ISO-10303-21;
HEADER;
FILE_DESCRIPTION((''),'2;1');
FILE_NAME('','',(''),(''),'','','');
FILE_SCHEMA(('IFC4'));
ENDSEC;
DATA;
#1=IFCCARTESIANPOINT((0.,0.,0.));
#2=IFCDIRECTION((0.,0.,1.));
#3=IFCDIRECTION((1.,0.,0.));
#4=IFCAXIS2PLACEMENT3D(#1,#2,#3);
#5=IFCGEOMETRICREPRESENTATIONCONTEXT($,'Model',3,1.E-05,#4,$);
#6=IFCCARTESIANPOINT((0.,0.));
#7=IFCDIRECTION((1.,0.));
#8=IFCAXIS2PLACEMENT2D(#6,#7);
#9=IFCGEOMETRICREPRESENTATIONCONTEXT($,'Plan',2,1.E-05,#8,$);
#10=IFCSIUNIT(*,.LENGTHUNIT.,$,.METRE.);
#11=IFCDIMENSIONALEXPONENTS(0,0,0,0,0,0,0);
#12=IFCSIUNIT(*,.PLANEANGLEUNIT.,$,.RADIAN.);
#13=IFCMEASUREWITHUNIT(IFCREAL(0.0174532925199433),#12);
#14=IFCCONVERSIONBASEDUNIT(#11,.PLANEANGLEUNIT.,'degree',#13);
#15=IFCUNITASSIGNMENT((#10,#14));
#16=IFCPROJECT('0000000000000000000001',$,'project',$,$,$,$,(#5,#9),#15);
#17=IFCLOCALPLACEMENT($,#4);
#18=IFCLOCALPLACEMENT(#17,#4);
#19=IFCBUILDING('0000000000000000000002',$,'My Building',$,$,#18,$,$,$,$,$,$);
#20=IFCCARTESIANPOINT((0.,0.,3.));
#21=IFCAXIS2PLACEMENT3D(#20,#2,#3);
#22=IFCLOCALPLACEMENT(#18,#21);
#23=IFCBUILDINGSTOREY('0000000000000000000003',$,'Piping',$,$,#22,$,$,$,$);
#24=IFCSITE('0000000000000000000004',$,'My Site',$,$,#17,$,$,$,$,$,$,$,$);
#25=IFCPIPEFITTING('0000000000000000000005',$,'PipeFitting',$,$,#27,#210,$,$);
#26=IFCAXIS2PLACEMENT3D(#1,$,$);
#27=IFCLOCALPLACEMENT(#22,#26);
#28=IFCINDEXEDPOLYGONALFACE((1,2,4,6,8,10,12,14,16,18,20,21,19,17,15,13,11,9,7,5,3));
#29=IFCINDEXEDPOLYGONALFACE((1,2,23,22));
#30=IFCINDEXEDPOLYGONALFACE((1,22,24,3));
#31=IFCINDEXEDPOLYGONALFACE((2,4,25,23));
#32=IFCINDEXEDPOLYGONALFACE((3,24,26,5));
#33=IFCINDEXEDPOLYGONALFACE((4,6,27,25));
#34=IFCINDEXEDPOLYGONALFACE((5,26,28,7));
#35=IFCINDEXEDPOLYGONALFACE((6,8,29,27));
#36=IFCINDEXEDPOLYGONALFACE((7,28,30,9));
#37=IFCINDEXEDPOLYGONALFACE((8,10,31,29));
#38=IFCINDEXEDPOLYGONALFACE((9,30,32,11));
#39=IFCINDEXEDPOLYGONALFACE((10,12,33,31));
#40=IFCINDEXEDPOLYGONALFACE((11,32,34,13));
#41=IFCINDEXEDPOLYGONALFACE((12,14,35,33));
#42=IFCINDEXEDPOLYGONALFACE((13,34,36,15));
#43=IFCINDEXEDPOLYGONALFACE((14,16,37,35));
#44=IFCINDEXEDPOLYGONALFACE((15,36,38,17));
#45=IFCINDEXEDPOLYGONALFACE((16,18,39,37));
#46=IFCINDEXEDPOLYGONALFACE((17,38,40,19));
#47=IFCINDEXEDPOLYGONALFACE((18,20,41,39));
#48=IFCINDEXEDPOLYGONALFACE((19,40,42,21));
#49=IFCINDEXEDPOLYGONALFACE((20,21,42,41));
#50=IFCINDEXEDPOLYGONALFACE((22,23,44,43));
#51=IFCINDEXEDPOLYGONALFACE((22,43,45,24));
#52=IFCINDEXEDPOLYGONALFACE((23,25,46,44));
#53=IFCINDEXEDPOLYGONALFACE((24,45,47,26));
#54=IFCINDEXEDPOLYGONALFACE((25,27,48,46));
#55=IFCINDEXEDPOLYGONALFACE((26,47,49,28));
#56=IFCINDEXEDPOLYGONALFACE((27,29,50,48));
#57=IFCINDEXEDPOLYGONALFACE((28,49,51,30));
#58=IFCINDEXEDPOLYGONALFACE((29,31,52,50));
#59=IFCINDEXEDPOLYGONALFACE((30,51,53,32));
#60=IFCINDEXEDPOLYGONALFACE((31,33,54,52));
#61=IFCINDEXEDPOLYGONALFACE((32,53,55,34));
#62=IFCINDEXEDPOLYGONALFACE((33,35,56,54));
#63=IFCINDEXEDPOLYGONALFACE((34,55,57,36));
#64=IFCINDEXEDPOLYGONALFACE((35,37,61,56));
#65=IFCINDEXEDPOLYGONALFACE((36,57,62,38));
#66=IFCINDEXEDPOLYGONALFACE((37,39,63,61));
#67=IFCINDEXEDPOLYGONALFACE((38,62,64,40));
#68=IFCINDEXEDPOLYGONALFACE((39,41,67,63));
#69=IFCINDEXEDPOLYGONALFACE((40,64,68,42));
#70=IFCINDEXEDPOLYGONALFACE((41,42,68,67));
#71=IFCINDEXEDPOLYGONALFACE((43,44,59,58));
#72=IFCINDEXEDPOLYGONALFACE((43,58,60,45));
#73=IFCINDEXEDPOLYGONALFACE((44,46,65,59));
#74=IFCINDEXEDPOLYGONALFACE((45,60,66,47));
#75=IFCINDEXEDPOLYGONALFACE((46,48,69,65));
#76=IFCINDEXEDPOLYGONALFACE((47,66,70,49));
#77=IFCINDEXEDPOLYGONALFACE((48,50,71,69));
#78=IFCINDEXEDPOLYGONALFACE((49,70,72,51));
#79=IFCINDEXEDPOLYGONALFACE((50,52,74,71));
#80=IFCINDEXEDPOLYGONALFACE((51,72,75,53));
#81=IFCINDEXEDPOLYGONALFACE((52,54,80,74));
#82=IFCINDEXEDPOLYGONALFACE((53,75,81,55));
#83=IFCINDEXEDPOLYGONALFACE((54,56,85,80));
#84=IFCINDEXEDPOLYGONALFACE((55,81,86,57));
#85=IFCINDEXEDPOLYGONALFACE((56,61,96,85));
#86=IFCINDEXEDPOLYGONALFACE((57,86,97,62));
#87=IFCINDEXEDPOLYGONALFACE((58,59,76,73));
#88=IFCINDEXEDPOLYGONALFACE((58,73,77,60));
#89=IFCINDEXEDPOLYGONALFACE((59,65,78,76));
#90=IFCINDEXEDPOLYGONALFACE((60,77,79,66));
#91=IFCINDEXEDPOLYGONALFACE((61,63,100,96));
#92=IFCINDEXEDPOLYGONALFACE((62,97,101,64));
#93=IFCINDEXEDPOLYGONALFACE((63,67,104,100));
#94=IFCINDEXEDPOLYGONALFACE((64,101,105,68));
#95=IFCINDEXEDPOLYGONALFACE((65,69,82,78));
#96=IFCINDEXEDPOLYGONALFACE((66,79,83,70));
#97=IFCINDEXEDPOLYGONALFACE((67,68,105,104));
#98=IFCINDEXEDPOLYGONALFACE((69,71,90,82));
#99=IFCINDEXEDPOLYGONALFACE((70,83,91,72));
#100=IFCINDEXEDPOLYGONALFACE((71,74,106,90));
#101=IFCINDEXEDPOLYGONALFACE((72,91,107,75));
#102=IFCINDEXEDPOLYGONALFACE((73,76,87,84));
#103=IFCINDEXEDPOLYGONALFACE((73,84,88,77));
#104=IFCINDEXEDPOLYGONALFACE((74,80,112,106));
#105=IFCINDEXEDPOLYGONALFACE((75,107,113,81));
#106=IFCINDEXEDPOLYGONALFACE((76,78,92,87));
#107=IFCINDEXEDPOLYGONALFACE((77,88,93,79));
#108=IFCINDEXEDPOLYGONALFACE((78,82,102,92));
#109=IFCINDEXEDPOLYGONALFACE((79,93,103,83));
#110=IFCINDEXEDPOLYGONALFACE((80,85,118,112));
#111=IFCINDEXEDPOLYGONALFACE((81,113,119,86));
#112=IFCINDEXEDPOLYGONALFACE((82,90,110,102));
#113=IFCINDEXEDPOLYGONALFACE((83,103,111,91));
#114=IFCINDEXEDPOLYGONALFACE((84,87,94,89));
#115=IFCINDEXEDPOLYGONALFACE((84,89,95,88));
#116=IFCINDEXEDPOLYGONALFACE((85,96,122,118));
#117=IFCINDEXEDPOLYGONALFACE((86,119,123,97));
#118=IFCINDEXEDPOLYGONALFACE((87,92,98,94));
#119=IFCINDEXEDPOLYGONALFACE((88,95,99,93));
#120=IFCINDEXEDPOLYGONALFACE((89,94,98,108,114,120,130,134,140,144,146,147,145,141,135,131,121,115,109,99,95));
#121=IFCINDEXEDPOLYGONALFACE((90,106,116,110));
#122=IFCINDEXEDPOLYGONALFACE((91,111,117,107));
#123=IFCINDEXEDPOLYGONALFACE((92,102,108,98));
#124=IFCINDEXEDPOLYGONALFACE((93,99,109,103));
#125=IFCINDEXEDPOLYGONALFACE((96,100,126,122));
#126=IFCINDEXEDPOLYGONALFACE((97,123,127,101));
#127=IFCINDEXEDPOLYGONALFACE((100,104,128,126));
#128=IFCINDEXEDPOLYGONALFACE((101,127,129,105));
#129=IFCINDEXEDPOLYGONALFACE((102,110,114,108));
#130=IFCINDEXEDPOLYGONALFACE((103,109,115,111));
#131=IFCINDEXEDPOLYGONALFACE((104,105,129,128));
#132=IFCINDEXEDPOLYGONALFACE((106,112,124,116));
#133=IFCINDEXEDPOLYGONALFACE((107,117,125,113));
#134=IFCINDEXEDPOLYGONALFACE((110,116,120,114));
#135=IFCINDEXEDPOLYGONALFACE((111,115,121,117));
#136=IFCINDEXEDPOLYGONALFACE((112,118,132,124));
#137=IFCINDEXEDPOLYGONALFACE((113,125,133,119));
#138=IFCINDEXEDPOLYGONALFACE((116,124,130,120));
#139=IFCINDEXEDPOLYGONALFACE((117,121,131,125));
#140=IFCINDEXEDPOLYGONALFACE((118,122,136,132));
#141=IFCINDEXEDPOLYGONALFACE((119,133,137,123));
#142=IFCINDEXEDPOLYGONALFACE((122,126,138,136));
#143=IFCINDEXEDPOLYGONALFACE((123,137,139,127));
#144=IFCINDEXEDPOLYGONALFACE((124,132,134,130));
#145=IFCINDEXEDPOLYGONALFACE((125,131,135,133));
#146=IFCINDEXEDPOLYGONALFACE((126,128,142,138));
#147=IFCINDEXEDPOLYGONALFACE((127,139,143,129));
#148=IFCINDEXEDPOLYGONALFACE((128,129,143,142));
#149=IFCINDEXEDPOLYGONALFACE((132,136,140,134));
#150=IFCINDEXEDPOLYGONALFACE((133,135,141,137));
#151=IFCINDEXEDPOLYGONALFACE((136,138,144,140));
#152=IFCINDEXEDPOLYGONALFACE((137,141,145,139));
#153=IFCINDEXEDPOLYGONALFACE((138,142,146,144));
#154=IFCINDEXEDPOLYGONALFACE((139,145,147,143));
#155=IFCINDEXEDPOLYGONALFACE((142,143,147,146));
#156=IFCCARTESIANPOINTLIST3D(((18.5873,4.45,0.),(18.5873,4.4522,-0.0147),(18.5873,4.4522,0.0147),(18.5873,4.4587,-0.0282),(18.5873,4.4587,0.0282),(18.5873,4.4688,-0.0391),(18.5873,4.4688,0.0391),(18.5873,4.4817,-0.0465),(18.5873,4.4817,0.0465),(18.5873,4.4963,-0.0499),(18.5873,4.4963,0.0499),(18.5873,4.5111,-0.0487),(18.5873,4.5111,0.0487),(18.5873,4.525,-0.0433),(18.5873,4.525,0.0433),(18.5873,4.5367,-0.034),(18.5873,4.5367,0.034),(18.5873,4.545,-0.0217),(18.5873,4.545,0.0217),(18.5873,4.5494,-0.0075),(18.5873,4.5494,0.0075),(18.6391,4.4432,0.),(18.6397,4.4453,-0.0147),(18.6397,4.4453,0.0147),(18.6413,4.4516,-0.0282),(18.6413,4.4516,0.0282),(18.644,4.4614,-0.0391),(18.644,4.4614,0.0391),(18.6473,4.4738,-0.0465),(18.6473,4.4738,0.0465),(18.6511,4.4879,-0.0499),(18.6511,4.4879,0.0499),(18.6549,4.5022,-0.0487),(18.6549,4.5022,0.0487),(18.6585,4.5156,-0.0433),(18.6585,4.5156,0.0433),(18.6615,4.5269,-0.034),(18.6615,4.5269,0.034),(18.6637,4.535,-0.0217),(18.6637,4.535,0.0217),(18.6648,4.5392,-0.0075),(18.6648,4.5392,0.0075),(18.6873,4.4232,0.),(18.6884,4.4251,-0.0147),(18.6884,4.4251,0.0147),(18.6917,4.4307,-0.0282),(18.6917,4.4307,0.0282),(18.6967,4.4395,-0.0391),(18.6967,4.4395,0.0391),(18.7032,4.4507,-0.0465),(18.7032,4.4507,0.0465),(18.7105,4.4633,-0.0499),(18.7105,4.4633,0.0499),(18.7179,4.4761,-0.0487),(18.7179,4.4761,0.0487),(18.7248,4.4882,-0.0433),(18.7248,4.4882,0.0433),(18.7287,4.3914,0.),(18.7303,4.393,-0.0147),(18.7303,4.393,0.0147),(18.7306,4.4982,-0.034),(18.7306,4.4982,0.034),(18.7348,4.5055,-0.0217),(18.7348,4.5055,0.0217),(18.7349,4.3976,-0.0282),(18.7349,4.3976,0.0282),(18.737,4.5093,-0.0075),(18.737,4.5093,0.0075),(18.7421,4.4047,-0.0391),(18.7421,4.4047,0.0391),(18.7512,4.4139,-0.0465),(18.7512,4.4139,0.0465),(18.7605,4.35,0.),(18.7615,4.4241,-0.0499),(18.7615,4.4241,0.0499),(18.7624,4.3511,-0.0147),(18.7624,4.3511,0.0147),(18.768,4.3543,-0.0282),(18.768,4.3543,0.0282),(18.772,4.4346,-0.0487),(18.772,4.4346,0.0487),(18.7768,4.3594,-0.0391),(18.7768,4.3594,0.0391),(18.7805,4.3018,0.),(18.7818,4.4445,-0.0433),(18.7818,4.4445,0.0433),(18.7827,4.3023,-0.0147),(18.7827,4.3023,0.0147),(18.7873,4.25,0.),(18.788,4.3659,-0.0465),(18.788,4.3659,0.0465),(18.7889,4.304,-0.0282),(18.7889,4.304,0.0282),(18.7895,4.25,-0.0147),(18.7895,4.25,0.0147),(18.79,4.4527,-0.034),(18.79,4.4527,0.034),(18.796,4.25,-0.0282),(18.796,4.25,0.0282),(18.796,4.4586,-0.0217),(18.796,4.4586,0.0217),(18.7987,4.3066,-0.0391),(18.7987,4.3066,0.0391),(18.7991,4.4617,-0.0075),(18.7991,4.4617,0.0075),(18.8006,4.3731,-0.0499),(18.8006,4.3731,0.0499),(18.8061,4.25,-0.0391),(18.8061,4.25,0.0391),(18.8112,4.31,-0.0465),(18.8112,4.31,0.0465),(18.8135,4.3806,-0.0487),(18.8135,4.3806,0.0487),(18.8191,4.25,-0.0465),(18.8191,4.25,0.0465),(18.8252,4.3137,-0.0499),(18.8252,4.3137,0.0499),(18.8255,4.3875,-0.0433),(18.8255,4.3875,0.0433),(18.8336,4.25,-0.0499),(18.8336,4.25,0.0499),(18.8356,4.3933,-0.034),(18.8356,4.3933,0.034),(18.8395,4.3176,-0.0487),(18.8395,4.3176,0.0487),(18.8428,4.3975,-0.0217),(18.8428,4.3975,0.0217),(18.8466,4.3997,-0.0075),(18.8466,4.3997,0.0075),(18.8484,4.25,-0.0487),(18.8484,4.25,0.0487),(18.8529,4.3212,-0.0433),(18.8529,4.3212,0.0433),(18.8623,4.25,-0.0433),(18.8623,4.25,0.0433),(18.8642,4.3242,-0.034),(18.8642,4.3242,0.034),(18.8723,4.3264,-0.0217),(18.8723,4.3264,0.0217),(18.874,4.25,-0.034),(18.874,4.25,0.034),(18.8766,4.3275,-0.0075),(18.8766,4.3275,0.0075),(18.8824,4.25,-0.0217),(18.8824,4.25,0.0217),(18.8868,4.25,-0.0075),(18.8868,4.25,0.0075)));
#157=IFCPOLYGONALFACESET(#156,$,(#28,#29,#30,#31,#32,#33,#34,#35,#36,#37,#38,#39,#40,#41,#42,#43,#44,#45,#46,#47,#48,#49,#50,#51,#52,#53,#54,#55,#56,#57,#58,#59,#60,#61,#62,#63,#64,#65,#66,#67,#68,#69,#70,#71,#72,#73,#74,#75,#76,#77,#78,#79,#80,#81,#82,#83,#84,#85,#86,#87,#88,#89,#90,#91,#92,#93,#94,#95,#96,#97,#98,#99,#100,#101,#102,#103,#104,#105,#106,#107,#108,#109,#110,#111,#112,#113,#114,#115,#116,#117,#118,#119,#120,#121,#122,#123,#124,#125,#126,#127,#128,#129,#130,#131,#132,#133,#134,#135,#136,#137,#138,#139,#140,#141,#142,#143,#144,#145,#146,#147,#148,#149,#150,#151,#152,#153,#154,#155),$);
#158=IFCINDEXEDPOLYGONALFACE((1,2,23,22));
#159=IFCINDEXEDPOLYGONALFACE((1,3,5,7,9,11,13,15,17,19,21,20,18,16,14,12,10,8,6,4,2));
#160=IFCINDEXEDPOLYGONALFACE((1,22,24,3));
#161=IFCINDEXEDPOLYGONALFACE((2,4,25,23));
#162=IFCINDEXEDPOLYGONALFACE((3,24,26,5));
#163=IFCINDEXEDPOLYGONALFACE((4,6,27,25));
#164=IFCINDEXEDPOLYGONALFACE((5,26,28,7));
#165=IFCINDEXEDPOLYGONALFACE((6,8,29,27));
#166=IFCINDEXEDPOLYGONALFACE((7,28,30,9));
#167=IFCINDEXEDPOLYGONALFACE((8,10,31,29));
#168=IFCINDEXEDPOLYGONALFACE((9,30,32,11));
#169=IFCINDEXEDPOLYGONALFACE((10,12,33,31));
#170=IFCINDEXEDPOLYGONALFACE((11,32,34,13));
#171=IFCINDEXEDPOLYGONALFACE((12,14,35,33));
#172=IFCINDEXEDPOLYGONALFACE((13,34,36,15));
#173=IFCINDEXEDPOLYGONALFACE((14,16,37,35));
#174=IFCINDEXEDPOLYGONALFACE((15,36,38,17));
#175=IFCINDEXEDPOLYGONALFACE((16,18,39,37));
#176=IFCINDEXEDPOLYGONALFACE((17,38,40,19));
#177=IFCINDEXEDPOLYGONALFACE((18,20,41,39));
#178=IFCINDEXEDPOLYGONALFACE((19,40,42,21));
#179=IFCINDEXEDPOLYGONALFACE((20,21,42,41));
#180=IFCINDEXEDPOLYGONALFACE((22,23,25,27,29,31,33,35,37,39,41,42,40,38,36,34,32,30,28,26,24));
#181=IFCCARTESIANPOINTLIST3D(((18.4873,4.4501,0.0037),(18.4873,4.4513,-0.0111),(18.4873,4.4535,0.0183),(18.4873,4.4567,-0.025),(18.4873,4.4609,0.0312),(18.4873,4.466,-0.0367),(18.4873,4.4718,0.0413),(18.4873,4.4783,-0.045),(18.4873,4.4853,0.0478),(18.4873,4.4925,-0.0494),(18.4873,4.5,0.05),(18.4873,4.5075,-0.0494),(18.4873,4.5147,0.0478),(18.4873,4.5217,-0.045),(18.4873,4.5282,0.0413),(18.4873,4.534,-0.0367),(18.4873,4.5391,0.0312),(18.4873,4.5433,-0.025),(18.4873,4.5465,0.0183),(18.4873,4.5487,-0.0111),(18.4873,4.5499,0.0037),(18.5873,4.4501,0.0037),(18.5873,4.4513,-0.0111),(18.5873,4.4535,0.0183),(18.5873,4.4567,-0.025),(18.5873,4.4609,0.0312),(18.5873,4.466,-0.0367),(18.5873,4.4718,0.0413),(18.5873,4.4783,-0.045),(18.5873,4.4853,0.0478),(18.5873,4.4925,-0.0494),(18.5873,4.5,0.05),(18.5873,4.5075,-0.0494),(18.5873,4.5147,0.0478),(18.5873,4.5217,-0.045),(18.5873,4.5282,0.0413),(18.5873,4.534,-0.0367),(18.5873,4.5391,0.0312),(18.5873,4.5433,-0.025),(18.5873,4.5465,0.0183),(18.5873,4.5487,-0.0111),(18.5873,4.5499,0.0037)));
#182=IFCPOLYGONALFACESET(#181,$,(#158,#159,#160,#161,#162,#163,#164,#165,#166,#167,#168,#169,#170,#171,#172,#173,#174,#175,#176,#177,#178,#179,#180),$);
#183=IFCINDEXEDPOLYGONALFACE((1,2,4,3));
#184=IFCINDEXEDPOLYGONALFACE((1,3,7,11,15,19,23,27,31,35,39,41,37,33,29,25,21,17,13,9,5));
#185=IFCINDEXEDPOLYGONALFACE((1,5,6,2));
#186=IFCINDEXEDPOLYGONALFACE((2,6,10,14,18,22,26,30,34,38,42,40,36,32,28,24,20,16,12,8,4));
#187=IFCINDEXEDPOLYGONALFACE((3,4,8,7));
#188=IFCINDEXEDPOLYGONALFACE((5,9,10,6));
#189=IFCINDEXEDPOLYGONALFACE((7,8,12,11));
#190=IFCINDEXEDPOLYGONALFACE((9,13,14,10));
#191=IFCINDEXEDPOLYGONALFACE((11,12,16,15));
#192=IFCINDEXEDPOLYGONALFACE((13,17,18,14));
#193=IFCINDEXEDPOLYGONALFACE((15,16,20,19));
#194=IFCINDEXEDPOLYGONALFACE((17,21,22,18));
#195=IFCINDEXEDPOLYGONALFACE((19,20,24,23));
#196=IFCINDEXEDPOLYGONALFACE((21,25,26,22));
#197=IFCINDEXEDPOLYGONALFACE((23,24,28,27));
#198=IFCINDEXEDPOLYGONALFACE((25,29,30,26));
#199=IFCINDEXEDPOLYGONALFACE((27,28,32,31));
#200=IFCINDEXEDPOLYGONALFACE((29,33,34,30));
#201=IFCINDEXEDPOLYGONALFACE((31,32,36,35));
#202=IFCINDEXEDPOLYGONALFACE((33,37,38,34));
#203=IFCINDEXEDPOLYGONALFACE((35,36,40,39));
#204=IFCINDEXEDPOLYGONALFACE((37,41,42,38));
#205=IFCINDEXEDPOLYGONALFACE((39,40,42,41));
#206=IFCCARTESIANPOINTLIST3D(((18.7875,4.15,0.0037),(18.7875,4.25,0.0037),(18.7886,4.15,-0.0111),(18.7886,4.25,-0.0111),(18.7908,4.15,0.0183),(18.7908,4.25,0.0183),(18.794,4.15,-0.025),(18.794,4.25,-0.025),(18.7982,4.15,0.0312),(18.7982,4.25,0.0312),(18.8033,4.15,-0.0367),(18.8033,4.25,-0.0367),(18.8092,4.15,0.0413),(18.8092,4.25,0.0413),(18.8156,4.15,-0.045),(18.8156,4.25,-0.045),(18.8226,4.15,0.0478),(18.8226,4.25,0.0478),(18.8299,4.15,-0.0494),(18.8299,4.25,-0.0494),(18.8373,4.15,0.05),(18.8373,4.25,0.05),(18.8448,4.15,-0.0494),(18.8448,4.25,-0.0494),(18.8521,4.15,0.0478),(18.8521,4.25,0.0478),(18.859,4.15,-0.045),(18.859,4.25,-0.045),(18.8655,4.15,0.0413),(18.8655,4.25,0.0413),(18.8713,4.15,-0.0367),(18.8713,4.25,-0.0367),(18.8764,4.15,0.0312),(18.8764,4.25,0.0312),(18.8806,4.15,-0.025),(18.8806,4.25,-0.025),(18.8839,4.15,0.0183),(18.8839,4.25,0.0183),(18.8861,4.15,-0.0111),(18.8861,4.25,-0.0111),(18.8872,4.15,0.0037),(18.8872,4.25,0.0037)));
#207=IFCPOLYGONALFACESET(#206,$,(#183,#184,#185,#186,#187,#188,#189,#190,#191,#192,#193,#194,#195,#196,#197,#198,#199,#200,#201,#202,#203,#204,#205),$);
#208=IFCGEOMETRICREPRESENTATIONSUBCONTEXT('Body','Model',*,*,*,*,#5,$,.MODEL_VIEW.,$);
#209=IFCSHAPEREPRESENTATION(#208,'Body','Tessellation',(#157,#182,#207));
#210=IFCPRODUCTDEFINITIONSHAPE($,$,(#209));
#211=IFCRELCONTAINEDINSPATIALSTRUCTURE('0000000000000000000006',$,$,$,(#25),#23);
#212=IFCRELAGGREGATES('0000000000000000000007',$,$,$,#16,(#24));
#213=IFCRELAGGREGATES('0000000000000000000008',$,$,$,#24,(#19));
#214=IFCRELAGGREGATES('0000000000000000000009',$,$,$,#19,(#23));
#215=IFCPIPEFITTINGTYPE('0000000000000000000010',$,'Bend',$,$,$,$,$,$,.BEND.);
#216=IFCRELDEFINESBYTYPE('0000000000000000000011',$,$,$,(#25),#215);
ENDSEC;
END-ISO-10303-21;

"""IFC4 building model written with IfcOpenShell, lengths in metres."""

from ifc_helpers import new_model, entity, si_unit, converted_unit, frame, origin_with_axes, origin_2d_with_axis, place, context, subcontext, project, spatial, circle, extrude, source, transform, mapped, type_object, type_shapes, element, save


model = new_model("IFC4")

# Units and contexts
model_context = context("Model", 3, precision=1e-05, world=origin_with_axes())
plan_context = context("Plan", 2, precision=1e-05, world=origin_2d_with_axis())
body_context = subcontext(model_context, "Body", "Model", "MODEL_VIEW")
ifc_project = project(units=[si_unit("LENGTHUNIT", "METRE"), converted_unit("PLANEANGLEUNIT", "degree", entity("IfcReal", 0.0174532925199433), si_unit("PLANEANGLEUNIT", "RADIAN"), dimensions=[0, 0, 0, 0, 0, 0, 0])], contexts=[model_context, plan_context])

# Site, building, storey
site_placement = place(None, origin_with_axes())
site = spatial("IfcSite", under=ifc_project, at=site_placement, Name="My Site")
building_placement = place(site_placement, origin_with_axes())
building = spatial("IfcBuilding", under=site, at=building_placement, Name="My Building")
storey_placement = place(building_placement, frame((0.0, 0.0, 3.0), z_axis=(0.0, 0.0, 1.0), x_axis=(1.0, 0.0, 0.0)))
storey = spatial("IfcBuildingStorey", under=building, at=storey_placement, Name="Piping")

# Pipe fitting
pipe_fitting_type = type_object("IfcPipeFittingType", Name="Bend", PredefinedType="BEND")
shared_shape = source(origin_with_axes(), body_context, "Body", "SolidModel", [
    entity("IfcSweptDiskSolid", entity("IfcIndexedPolyCurve", entity("IfcCartesianPointList3D", [[0.0, 0.0, -0.1], [0.0, -0.0732, -0.2768], [0.0, -0.25, -0.35]]), [entity("IfcArcIndex", [1, 2, 3])]), 0.05),
    extrude(circle(Radius=0.05), origin_with_axes(), (0.0, 0.0, -1.0), 0.1),
    extrude(circle(Radius=0.05), frame((0.0, -0.25, -0.35), z_axis=(0.0, -1.0, 0.0), x_axis=(1.0, 0.0, 0.0)), (0.0, 0.0, 1.0), 0.1),
])
type_shapes(pipe_fitting_type, [shared_shape])
for number, where, z_axis, x_axis, name in (
    (1, (18.4873, 4.5, 0.0), (-1.0, 0.0, 0.0), (0.0, 0.0, 1.0), "PipeFitting"),
):
    element("IfcPipeFitting", number, at=place(storey_placement, frame(where, z_axis=z_axis, x_axis=x_axis)), inside=storey, type_object=pipe_fitting_type, Name=name, context=body_context, shape_type="MappedRepresentation", body=[
        mapped(shared_shape, transform((0.0, 0.0, 0.0), x_axis=(1.0, 0.0, 0.0), y_axis=(0.0, 1.0, 0.0), z_axis=(0.0, 0.0, 1.0), scale=1.0)),
    ])

save(model, "model.ifc")
